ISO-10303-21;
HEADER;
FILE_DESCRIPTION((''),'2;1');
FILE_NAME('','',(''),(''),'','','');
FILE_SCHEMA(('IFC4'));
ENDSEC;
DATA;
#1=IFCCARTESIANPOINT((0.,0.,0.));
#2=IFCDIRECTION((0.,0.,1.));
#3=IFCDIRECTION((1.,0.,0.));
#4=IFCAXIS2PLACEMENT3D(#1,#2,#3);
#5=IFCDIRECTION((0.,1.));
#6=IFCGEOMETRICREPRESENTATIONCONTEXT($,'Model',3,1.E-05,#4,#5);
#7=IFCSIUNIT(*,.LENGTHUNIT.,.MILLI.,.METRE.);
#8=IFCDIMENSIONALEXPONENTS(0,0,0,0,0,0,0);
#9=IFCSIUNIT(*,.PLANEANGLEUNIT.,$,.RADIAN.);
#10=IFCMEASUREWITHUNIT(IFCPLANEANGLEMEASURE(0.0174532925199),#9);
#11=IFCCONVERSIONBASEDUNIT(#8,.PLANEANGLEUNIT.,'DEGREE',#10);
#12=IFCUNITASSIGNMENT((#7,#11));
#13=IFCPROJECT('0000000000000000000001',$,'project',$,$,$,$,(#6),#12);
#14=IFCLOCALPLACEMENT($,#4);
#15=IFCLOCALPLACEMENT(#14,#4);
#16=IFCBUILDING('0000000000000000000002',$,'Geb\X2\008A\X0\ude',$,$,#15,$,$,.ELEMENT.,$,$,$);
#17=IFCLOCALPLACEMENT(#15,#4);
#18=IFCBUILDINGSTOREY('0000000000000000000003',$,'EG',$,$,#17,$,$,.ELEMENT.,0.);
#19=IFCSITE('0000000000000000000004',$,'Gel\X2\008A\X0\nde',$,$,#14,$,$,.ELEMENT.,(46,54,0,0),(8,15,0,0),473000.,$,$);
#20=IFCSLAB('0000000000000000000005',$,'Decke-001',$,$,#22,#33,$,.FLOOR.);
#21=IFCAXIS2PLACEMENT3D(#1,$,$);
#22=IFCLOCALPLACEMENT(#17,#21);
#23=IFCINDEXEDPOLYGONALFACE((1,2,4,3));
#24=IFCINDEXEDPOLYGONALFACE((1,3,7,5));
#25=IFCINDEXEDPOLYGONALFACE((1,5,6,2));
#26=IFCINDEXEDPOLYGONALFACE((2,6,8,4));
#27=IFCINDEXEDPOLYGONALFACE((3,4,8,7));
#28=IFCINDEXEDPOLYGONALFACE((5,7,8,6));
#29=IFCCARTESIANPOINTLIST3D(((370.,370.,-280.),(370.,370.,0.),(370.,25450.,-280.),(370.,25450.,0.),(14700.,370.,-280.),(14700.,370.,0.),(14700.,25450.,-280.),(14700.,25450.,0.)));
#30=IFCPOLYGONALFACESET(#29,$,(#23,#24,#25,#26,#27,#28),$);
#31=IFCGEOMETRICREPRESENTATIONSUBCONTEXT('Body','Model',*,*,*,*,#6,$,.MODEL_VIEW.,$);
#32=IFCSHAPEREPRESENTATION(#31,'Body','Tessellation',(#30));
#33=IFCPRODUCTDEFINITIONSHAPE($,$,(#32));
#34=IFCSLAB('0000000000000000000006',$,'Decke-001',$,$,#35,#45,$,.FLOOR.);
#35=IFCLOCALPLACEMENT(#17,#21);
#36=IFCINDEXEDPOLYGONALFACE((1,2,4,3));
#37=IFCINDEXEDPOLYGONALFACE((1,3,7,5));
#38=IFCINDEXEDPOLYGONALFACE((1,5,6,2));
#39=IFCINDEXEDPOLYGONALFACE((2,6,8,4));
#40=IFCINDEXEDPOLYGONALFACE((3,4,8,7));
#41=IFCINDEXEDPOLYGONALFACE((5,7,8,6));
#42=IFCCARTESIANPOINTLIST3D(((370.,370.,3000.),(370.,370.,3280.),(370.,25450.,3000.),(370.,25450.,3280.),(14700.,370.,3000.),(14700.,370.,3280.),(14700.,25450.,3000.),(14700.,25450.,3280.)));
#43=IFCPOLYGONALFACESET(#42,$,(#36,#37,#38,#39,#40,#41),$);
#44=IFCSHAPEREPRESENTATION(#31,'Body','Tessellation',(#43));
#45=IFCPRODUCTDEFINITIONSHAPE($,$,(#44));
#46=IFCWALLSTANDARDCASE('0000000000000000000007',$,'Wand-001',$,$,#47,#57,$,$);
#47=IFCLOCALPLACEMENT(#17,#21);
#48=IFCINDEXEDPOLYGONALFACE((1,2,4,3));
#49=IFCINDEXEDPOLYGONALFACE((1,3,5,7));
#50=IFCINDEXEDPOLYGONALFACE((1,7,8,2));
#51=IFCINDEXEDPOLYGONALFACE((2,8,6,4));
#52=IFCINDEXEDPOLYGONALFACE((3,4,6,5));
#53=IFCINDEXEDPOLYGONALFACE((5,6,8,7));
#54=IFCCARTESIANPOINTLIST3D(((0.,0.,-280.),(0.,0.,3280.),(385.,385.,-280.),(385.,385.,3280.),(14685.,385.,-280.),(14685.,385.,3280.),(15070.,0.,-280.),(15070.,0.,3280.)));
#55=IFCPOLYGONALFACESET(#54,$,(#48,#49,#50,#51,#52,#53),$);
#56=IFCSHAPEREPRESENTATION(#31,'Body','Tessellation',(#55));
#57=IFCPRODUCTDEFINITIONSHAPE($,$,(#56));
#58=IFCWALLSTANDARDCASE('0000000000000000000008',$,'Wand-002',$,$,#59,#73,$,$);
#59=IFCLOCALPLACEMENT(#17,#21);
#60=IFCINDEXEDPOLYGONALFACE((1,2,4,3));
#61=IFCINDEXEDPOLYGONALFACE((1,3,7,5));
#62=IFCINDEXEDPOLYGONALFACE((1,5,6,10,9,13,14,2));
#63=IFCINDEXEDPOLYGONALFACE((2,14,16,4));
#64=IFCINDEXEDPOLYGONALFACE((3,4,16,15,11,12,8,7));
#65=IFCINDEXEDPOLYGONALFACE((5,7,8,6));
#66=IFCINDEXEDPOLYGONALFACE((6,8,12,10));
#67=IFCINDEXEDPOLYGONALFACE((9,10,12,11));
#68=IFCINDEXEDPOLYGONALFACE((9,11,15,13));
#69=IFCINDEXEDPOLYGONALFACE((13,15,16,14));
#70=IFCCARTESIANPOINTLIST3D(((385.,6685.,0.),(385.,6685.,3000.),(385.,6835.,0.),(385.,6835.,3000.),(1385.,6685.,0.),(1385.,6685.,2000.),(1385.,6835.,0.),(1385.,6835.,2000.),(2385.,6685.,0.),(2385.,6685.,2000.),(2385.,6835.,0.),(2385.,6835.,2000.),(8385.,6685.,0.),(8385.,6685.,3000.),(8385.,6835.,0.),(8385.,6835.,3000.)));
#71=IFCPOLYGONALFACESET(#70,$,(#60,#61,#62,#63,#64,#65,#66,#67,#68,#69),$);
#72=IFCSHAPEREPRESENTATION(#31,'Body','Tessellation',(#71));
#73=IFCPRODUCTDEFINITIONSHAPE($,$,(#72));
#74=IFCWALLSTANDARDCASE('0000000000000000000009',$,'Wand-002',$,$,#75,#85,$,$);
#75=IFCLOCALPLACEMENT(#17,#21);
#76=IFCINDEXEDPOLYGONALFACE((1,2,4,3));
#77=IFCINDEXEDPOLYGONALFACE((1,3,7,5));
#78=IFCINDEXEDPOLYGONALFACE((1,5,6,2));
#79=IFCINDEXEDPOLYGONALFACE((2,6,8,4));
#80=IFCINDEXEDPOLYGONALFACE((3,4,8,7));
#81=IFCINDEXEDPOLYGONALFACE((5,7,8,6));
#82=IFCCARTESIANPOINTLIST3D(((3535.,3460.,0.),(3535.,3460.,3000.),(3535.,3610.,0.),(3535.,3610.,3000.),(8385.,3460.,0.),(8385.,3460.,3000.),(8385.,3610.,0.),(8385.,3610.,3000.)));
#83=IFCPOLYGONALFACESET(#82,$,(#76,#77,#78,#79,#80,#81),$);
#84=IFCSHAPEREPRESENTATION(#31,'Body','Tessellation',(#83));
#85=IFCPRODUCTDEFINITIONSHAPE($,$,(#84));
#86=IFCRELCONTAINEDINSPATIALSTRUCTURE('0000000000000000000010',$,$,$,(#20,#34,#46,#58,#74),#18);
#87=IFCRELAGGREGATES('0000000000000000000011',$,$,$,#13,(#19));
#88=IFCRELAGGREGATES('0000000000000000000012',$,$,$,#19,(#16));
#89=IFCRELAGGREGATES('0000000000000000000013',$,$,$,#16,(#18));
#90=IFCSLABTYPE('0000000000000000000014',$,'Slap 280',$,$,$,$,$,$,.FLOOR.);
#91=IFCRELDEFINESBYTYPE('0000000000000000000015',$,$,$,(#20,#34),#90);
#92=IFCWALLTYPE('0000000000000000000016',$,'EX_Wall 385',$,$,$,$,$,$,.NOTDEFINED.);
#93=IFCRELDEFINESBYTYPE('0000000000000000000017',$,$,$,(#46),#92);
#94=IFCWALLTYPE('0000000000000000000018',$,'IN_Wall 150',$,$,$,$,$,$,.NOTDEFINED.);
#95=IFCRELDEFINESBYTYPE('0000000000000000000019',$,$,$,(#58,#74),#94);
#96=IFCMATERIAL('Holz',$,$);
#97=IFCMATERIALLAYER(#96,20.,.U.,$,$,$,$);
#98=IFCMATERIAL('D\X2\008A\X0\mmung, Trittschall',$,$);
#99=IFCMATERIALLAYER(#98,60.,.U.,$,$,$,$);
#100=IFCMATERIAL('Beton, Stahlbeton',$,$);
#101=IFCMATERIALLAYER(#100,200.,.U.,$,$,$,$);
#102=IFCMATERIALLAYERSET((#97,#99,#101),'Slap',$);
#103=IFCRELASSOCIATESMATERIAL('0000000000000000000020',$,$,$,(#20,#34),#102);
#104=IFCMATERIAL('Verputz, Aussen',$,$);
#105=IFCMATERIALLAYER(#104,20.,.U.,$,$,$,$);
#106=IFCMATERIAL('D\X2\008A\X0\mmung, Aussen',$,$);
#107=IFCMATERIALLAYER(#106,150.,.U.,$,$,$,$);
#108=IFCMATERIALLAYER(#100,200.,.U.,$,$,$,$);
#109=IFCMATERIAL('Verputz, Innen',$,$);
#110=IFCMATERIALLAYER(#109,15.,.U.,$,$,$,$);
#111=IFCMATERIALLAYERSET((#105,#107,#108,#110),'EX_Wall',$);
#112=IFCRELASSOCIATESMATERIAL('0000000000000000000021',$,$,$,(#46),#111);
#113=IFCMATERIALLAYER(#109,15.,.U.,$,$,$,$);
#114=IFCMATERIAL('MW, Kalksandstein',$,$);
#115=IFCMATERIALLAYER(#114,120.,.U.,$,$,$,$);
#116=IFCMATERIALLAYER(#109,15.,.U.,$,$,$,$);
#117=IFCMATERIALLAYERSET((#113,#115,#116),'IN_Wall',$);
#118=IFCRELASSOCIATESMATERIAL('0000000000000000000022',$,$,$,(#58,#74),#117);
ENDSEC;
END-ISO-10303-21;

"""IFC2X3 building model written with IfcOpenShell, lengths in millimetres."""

from ifc_helpers import new_model, entity, si_unit, converted_unit, direction, frame, origin_with_axes, origin_2d_with_axis, place, context, subcontext, project, spatial, polyline, rectangle, outline, extrude, material, layer, layer_set, layer_usage, type_object, element, save


model = new_model("IFC2X3")

# Units and contexts
model_context = context("Model", 3, precision=1e-05, world=origin_with_axes(), true_north=direction((0.0, 1.0)))
body_context = subcontext(model_context, "Body", "Model", "MODEL_VIEW")
ifc_project = project(units=[si_unit("LENGTHUNIT", "METRE", prefix="MILLI"), converted_unit("PLANEANGLEUNIT", "DEGREE", entity("IfcPlaneAngleMeasure", 0.0174532925199), si_unit("PLANEANGLEUNIT", "RADIAN"), dimensions=[0, 0, 0, 0, 0, 0, 0])], contexts=[model_context])

# Site, building, storey
site_placement = place(None, origin_with_axes())
site = spatial("IfcSite", under=ifc_project, at=site_placement, Name="Gel\u008ande", CompositionType="ELEMENT", RefLatitude=(46, 54, 0, 0), RefLongitude=(8, 15, 0, 0), RefElevation=473000.0)
building_placement = place(site_placement, origin_with_axes())
building = spatial("IfcBuilding", under=site, at=building_placement, Name="Geb\u008aude", CompositionType="ELEMENT")
storey_placement = place(building_placement, origin_with_axes())
storey = spatial("IfcBuildingStorey", under=building, at=storey_placement, Name="EG", CompositionType="ELEMENT", Elevation=0.0)

# Slabs
ifc_material_1 = material(Name="Holz")
ifc_layer_1 = layer(ifc_material_1, 20.0, ventilated="UNKNOWN")
ifc_material_2 = material(Name="D\u008ammung, Trittschall")
ifc_layer_2 = layer(ifc_material_2, 60.0, ventilated="UNKNOWN")
ifc_material_3 = material(Name="Beton, Stahlbeton")
ifc_layer_3 = layer(ifc_material_3, 200.0, ventilated="UNKNOWN")
ifc_layer_set_1 = layer_set([ifc_layer_1, ifc_layer_2, ifc_layer_3], Name="Slap")
ifc_layer_usage_1 = layer_usage(ifc_layer_set_1, "AXIS3", "NEGATIVE", 280.0)
slab_type = type_object("IfcSlabType", Name="Slap 280", PredefinedType="FLOOR")
slab_1_placement = place(storey_placement, frame((370.0, 370.0, 0.0), z_axis=(0.0, 0.0, 1.0), x_axis=(1.0, 0.0, 0.0)))
element("IfcSlab", 1, at=slab_1_placement, inside=storey, type_object=slab_type, material=ifc_layer_usage_1, Name="Decke-001", PredefinedType="FLOOR", context=body_context, shape_type="SweptSolid", body=[
    extrude(outline(polyline([(0.0, 0.0), (14330.0, 0.0), (14330.0, 25080.0), (0.0, 25080.0), (0.0, 0.0)])), frame((0.0, 0.0, -280.0), z_axis=(0.0, 0.0, 1.0), x_axis=(1.0, 0.0, 0.0)), (0.0, 0.0, 1.0), 280.0),
])
ifc_layer_usage_2 = layer_usage(ifc_layer_set_1, "AXIS3", "NEGATIVE", 280.0)
slab_2_placement = place(storey_placement, frame((370.0, 370.0, 3280.0), z_axis=(0.0, 0.0, 1.0), x_axis=(1.0, 0.0, 0.0)))
element("IfcSlab", 2, at=slab_2_placement, inside=storey, type_object=slab_type, material=ifc_layer_usage_2, Name="Decke-001", PredefinedType="FLOOR", context=body_context, shape_type="SweptSolid", body=[
    extrude(outline(polyline([(0.0, 0.0), (14330.0, 0.0), (14330.0, 25080.0), (0.0, 25080.0), (0.0, 0.0)])), frame((0.0, 0.0, -280.0), z_axis=(0.0, 0.0, 1.0), x_axis=(1.0, 0.0, 0.0)), (0.0, 0.0, 1.0), 280.0),
])

# Wall
ifc_material_4 = material(Name="Verputz, Aussen")
ifc_layer_4 = layer(ifc_material_4, 20.0, ventilated="UNKNOWN")
ifc_material_5 = material(Name="D\u008ammung, Aussen")
ifc_layer_5 = layer(ifc_material_5, 150.0, ventilated="UNKNOWN")
ifc_layer_6 = layer(ifc_material_3, 200.0, ventilated="UNKNOWN")
ifc_material_6 = material(Name="Verputz, Innen")
ifc_layer_7 = layer(ifc_material_6, 15.0, ventilated="UNKNOWN")
ifc_layer_set_2 = layer_set([ifc_layer_4, ifc_layer_5, ifc_layer_6, ifc_layer_7], Name="EX_Wall")
ifc_layer_usage_3 = layer_usage(ifc_layer_set_2, "AXIS2", "POSITIVE", 0.0)
wall_type_1 = type_object("IfcWallType", Name="EX_Wall 385", PredefinedType="NOTDEFINED")
wall_1_placement = place(storey_placement, frame((385.0, 0.0, -280.0), z_axis=(0.0, 0.0, 1.0), x_axis=(1.0, 0.0, 0.0)))
element("IfcWallStandardCase", 3, at=wall_1_placement, inside=storey, type_object=wall_type_1, material=ifc_layer_usage_3, Name="Wand-001", context=body_context, shape_type="SweptSolid", body=[
    extrude(outline(polyline([(-385.0, 0.0), (14685.0, 0.0), (14300.0, 385.0), (0.0, 385.0), (-385.0, 0.0)])), origin_with_axes(), (0.0, 0.0, 1.0), 3560.0),
])
ifc_layer_8 = layer(ifc_material_6, 15.0, ventilated="UNKNOWN")
ifc_material_7 = material(Name="MW, Kalksandstein")
ifc_layer_9 = layer(ifc_material_7, 120.0, ventilated="UNKNOWN")
ifc_layer_10 = layer(ifc_material_6, 15.0, ventilated="UNKNOWN")
ifc_layer_set_3 = layer_set([ifc_layer_8, ifc_layer_9, ifc_layer_10], Name="IN_Wall")
wall_type_2 = type_object("IfcWallType", Name="IN_Wall 150", PredefinedType="NOTDEFINED")

# Wall, opening
ifc_layer_usage_4 = layer_usage(ifc_layer_set_3, "AXIS2", "POSITIVE", 0.0)
wall_2_placement = place(storey_placement, frame((8385.0, 6835.0, 0.0), z_axis=(0.0, 0.0, 1.0), x_axis=(-1.0, 0.0, 0.0)))
wall_2 = element("IfcWallStandardCase", 4, at=wall_2_placement, inside=storey, type_object=wall_type_2, material=ifc_layer_usage_4, Name="Wand-002", context=body_context, shape_type="SweptSolid", body=[
    extrude(outline(polyline([(0.0, 0.0), (8000.0, 0.0), (8000.0, 150.0), (0.0, 150.0), (0.0, 0.0)])), origin_with_axes(), (0.0, 0.0, 1.0), 3000.0),
])
opening_placement = place(wall_2_placement, frame((6500.0, 0.0, 0.0), z_axis=(0.0, 0.0, 1.0), x_axis=(1.0, 0.0, 0.0)))
element("IfcOpeningElement", 5, at=opening_placement, cuts=wall_2, context=body_context, shape_type="SweptSolid", body=[
    extrude(rectangle(XDim=1000.0, YDim=2000.0, at=origin_2d_with_axis()), frame((0.0, -150.0, 1000.0), z_axis=(0.0, -1.0, 0.0), x_axis=(-1.0, 0.0, 0.0)), (0.0, 0.0, -1.0), 450.0),
])

# Wall
ifc_layer_usage_5 = layer_usage(ifc_layer_set_3, "AXIS2", "POSITIVE", -75.0)
wall_3_placement = place(storey_placement, frame((3385.0, 3535.0, 0.0), z_axis=(0.0, 0.0, 1.0), x_axis=(1.0, 0.0, 0.0)))
element("IfcWallStandardCase", 6, at=wall_3_placement, inside=storey, type_object=wall_type_2, material=ifc_layer_usage_5, Name="Wand-002", context=body_context, shape_type="SweptSolid", body=[
    extrude(outline(polyline([(150.0, -75.0), (5000.0, -75.0), (5000.0, 75.0), (150.0, 75.0), (150.0, -75.0)])), origin_with_axes(), (0.0, 0.0, 1.0), 3000.0),
])

save(model, "model.ifc")
